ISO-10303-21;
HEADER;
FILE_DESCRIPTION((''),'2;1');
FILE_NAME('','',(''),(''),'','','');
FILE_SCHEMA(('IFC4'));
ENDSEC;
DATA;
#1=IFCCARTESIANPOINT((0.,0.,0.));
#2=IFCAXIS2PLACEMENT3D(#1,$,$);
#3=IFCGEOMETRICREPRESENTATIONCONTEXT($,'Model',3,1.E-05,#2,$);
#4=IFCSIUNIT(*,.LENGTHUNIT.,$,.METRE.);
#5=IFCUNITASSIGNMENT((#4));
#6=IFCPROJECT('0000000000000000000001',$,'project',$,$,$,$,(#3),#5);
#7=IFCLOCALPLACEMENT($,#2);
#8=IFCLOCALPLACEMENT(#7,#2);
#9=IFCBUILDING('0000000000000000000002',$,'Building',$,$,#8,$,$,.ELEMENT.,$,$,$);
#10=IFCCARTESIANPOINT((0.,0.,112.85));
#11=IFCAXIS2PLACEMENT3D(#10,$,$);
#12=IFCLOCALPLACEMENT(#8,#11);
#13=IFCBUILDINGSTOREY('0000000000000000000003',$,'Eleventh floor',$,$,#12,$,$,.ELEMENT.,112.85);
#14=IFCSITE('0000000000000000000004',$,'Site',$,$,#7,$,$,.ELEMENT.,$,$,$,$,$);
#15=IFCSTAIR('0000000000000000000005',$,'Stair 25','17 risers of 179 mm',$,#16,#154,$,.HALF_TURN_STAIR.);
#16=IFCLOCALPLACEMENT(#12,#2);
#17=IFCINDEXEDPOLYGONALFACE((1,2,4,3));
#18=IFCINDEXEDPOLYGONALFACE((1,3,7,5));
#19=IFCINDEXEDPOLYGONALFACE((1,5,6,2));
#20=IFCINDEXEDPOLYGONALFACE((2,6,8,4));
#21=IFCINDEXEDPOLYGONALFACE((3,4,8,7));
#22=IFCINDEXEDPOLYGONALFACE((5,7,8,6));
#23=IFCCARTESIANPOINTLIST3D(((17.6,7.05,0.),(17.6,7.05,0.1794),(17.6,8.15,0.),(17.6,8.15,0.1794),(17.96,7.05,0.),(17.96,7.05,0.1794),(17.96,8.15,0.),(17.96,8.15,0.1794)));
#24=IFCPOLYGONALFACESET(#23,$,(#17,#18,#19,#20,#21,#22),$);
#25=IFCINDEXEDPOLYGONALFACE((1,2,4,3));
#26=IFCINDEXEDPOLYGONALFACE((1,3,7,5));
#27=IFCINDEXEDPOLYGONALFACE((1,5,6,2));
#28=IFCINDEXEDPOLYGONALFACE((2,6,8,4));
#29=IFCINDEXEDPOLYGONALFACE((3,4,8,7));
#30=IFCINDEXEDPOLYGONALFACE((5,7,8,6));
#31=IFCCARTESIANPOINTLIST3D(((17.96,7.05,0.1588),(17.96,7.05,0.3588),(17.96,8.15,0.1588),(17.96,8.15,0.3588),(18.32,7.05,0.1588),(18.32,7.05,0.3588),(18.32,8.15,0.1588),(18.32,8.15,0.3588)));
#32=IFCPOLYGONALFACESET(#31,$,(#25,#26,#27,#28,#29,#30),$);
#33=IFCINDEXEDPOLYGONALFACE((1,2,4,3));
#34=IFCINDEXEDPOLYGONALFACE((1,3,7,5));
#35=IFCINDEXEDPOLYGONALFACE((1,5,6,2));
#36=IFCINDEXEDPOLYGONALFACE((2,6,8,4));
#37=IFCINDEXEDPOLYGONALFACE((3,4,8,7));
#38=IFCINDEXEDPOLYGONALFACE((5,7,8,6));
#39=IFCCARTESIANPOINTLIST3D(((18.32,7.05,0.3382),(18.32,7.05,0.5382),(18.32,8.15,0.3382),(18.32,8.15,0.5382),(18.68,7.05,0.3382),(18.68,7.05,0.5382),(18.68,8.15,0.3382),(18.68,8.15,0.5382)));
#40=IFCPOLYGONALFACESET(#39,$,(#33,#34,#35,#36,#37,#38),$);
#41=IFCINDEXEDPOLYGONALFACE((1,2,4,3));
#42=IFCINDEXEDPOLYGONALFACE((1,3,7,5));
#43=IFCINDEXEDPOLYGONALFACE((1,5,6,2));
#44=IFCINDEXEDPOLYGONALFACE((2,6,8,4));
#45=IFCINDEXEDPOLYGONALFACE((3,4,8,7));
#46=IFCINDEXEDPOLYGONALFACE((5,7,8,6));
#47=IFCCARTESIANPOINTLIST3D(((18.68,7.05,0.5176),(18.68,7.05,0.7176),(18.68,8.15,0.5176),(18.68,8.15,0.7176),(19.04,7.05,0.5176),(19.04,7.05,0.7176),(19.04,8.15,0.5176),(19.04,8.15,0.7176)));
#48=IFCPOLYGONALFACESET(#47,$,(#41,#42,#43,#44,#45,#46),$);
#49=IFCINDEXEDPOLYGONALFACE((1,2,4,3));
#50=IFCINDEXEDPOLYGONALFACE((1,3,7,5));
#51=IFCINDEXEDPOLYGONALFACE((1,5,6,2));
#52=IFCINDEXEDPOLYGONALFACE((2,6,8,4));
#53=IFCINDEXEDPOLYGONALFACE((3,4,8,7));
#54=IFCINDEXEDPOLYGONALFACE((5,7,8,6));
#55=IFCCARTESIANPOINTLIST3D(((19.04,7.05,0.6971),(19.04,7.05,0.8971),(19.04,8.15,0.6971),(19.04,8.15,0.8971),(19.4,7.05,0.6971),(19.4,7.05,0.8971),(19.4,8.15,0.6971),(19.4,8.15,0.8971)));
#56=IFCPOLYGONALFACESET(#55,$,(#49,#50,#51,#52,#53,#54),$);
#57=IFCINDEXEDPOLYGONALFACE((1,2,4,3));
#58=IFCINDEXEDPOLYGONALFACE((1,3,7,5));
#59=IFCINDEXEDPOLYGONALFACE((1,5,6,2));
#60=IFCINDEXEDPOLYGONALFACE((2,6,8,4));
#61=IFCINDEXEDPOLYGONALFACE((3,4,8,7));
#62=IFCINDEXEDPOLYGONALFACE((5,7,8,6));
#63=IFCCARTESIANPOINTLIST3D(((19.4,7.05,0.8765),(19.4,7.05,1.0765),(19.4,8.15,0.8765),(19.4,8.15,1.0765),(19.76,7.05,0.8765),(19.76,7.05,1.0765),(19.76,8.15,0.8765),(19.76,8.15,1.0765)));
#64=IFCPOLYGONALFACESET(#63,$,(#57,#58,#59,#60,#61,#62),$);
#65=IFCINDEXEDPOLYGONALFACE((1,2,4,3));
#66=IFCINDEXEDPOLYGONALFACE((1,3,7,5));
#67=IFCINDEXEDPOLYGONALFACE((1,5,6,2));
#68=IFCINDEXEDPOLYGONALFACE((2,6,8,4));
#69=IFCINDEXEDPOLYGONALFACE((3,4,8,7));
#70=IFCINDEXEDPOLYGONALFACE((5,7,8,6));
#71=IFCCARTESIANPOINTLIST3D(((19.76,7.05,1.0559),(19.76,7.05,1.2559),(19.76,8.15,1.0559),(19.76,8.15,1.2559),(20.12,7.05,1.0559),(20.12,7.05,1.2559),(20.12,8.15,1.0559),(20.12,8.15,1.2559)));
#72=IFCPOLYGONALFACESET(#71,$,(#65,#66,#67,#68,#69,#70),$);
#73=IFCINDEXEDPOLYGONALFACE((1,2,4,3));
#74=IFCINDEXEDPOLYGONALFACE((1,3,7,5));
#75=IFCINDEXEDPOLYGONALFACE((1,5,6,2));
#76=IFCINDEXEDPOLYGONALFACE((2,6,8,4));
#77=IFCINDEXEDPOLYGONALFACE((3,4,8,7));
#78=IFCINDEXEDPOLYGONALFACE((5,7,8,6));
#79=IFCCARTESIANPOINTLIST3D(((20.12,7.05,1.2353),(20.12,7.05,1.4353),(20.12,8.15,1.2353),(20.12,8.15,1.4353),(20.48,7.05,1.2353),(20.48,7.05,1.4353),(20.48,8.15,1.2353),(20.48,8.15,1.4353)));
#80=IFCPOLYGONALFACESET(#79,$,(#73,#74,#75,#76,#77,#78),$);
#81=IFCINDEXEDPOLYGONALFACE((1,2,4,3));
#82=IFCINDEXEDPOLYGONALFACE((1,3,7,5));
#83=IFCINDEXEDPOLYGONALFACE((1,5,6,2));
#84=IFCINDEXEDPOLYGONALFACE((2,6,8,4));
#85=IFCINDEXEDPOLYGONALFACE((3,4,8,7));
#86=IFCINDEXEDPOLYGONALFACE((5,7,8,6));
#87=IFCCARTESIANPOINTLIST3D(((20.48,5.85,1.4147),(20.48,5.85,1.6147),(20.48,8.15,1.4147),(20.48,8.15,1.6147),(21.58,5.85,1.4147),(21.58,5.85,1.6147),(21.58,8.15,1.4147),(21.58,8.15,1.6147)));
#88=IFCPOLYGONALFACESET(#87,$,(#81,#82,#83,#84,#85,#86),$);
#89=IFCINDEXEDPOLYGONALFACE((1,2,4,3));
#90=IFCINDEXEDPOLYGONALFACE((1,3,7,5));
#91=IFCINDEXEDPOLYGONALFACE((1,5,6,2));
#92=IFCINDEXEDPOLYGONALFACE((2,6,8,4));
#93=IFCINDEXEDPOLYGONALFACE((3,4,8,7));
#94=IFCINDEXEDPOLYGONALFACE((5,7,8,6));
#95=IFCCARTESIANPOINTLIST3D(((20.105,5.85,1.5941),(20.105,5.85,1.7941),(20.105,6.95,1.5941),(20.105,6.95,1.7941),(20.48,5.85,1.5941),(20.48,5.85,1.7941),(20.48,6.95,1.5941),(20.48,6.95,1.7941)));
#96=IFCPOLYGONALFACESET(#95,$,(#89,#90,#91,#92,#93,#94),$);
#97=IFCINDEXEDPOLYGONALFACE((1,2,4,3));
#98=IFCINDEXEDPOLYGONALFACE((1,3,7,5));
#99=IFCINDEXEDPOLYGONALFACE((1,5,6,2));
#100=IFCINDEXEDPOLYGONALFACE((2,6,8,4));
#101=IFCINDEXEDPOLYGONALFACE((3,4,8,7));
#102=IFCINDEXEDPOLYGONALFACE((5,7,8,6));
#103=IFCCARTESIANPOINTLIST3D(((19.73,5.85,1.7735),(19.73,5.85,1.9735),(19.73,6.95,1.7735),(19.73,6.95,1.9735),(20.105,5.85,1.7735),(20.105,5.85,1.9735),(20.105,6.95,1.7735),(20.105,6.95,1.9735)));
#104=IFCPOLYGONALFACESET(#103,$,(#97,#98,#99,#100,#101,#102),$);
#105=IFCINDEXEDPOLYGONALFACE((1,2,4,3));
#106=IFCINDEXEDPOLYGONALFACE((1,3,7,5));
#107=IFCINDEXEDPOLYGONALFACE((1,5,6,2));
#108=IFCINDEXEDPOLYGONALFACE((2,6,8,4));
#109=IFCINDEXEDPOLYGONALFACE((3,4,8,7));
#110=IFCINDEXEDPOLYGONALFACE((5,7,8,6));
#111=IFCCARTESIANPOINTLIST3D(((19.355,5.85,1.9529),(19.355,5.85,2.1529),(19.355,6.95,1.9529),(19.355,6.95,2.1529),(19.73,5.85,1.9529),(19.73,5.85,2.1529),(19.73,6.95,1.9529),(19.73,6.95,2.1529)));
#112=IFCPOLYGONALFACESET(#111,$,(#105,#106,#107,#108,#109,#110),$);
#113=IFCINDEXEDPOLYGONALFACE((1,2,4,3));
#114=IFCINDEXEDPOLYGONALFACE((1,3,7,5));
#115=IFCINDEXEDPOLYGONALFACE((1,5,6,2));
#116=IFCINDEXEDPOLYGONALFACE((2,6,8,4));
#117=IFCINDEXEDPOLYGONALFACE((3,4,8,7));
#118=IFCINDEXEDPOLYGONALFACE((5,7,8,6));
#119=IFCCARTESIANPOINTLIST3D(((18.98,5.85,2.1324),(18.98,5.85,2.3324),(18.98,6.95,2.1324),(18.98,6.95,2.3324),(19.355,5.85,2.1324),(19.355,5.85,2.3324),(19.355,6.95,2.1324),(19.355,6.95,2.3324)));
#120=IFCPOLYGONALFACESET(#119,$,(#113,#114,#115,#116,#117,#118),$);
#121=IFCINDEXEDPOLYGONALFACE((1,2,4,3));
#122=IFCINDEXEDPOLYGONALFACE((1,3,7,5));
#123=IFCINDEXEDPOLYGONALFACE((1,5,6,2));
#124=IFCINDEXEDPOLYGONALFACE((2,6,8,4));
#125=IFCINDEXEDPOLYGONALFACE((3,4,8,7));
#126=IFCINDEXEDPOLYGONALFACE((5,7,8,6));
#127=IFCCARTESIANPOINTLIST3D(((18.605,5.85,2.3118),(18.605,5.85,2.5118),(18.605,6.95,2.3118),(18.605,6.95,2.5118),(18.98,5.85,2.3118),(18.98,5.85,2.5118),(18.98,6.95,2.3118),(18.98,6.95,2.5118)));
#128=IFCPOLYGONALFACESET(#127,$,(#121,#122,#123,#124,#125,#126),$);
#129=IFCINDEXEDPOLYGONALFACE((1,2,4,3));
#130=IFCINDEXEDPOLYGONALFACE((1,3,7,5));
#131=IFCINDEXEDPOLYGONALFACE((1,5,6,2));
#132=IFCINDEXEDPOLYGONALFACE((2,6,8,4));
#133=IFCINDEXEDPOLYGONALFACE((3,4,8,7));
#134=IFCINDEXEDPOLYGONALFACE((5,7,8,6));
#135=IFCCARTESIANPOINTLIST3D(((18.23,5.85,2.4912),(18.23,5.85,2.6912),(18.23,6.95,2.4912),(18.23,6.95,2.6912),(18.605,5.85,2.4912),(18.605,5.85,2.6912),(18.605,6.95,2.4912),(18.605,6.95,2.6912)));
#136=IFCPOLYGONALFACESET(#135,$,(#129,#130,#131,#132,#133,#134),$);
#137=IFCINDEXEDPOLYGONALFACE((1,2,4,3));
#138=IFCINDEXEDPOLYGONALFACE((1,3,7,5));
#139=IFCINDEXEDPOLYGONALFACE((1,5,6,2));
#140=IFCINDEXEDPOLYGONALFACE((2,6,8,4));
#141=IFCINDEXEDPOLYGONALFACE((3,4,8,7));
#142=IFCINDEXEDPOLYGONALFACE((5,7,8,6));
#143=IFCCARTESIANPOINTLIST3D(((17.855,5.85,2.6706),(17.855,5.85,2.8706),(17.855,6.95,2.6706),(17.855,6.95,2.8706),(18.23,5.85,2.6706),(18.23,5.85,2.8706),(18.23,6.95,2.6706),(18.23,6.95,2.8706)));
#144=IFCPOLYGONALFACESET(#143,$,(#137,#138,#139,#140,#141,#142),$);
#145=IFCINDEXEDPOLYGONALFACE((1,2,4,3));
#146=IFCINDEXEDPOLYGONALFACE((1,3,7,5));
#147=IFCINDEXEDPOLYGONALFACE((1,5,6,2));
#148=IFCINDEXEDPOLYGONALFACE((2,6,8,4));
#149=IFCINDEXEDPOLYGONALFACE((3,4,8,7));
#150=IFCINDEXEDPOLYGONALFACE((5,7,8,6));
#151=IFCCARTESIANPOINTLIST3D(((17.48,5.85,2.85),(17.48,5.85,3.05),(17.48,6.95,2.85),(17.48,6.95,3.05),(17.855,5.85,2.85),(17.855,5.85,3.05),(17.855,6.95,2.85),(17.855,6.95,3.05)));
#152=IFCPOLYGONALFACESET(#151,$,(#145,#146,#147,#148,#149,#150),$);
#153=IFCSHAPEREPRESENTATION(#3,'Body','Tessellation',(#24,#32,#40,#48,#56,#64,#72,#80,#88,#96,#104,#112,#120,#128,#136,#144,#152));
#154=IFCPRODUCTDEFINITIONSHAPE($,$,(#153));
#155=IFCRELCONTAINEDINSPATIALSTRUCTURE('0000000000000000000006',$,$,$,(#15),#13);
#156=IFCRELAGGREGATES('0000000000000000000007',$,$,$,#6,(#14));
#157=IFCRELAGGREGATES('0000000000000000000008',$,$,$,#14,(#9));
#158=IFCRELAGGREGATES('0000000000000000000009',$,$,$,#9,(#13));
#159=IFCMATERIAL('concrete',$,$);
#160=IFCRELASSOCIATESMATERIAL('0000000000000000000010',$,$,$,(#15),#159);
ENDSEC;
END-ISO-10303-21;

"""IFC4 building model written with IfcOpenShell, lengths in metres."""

from ifc_helpers import new_model, si_unit, frame, origin, place, context, project, spatial, polyline, outline, extrude, material, element, save


model = new_model("IFC4")

# Units and contexts
model_context = context("Model", 3, precision=1e-05, world=origin())
ifc_project = project(units=[si_unit("LENGTHUNIT", "METRE")], contexts=[model_context])

# Site, building, storey
site_placement = place(None, origin())
site = spatial("IfcSite", under=ifc_project, at=site_placement, Name="Site", CompositionType="ELEMENT")
building_placement = place(site_placement, origin())
building = spatial("IfcBuilding", under=site, at=building_placement, Name="Building", CompositionType="ELEMENT")
storey_placement = place(building_placement, frame((0.0, 0.0, 112.85)))
storey = spatial("IfcBuildingStorey", under=building, at=storey_placement, Name="Eleventh floor", CompositionType="ELEMENT", Elevation=112.85)

# Shared definitions
ifc_material = material(Name="concrete")

# Stair
stair_1_placement = place(storey_placement, frame((17.6, 7.6, 0.0), z_axis=(0.0, 0.0, 1.0), x_axis=(1.0, 0.0, 0.0)))
element("IfcStair", 1, at=stair_1_placement, inside=storey, material=ifc_material, Name="Stair 25", Description="17 risers of 179 mm", PredefinedType="HALF_TURN_STAIR", context=model_context, shape_type="SweptSolid", body=[
    extrude(outline(polyline([(0.0, -0.55), (0.36, -0.55), (0.36, 0.55), (0.0, 0.55), (0.0, -0.55)])), origin(), (0.0, 0.0, 1.0), 0.1794),
    extrude(outline(polyline([(0.36, -0.55), (0.72, -0.55), (0.72, 0.55), (0.36, 0.55), (0.36, -0.55)])), frame((0.0, 0.0, 0.1588)), (0.0, 0.0, 1.0), 0.2),
    extrude(outline(polyline([(0.72, -0.55), (1.08, -0.55), (1.08, 0.55), (0.72, 0.55), (0.72, -0.55)])), frame((0.0, 0.0, 0.3382)), (0.0, 0.0, 1.0), 0.2),
    extrude(outline(polyline([(1.08, -0.55), (1.44, -0.55), (1.44, 0.55), (1.08, 0.55), (1.08, -0.55)])), frame((0.0, 0.0, 0.5176)), (0.0, 0.0, 1.0), 0.2),
    extrude(outline(polyline([(1.44, -0.55), (1.8, -0.55), (1.8, 0.55), (1.44, 0.55), (1.44, -0.55)])), frame((0.0, 0.0, 0.6971)), (0.0, 0.0, 1.0), 0.2),
    extrude(outline(polyline([(1.8, -0.55), (2.16, -0.55), (2.16, 0.55), (1.8, 0.55), (1.8, -0.55)])), frame((0.0, 0.0, 0.8765)), (0.0, 0.0, 1.0), 0.2),
    extrude(outline(polyline([(2.16, -0.55), (2.52, -0.55), (2.52, 0.55), (2.16, 0.55), (2.16, -0.55)])), frame((0.0, 0.0, 1.0559)), (0.0, 0.0, 1.0), 0.2),
    extrude(outline(polyline([(2.52, -0.55), (2.88, -0.55), (2.88, 0.55), (2.52, 0.55), (2.52, -0.55)])), frame((0.0, 0.0, 1.2353)), (0.0, 0.0, 1.0), 0.2),
    extrude(outline(polyline([(2.88, -1.75), (3.98, -1.75), (3.98, 0.55), (2.88, 0.55), (2.88, -1.75)])), frame((0.0, 0.0, 1.4147)), (0.0, 0.0, 1.0), 0.2),
    extrude(outline(polyline([(2.505, -1.75), (2.88, -1.75), (2.88, -0.65), (2.505, -0.65), (2.505, -1.75)])), frame((0.0, 0.0, 1.5941)), (0.0, 0.0, 1.0), 0.2),
    extrude(outline(polyline([(2.13, -1.75), (2.505, -1.75), (2.505, -0.65), (2.13, -0.65), (2.13, -1.75)])), frame((0.0, 0.0, 1.7735)), (0.0, 0.0, 1.0), 0.2),
    extrude(outline(polyline([(1.755, -1.75), (2.13, -1.75), (2.13, -0.65), (1.755, -0.65), (1.755, -1.75)])), frame((0.0, 0.0, 1.9529)), (0.0, 0.0, 1.0), 0.2),
    extrude(outline(polyline([(1.38, -1.75), (1.755, -1.75), (1.755, -0.65), (1.38, -0.65), (1.38, -1.75)])), frame((0.0, 0.0, 2.1324)), (0.0, 0.0, 1.0), 0.2),
    extrude(outline(polyline([(1.005, -1.75), (1.38, -1.75), (1.38, -0.65), (1.005, -0.65), (1.005, -1.75)])), frame((0.0, 0.0, 2.3118)), (0.0, 0.0, 1.0), 0.2),
    extrude(outline(polyline([(0.63, -1.75), (1.005, -1.75), (1.005, -0.65), (0.63, -0.65), (0.63, -1.75)])), frame((0.0, 0.0, 2.4912)), (0.0, 0.0, 1.0), 0.2),
    extrude(outline(polyline([(0.255, -1.75), (0.63, -1.75), (0.63, -0.65), (0.255, -0.65), (0.255, -1.75)])), frame((0.0, 0.0, 2.6706)), (0.0, 0.0, 1.0), 0.2),
    extrude(outline(polyline([(-0.12, -1.75), (0.255, -1.75), (0.255, -0.65), (-0.12, -0.65), (-0.12, -1.75)])), frame((0.0, 0.0, 2.85)), (0.0, 0.0, 1.0), 0.2),
])

save(model, "model.ifc")
